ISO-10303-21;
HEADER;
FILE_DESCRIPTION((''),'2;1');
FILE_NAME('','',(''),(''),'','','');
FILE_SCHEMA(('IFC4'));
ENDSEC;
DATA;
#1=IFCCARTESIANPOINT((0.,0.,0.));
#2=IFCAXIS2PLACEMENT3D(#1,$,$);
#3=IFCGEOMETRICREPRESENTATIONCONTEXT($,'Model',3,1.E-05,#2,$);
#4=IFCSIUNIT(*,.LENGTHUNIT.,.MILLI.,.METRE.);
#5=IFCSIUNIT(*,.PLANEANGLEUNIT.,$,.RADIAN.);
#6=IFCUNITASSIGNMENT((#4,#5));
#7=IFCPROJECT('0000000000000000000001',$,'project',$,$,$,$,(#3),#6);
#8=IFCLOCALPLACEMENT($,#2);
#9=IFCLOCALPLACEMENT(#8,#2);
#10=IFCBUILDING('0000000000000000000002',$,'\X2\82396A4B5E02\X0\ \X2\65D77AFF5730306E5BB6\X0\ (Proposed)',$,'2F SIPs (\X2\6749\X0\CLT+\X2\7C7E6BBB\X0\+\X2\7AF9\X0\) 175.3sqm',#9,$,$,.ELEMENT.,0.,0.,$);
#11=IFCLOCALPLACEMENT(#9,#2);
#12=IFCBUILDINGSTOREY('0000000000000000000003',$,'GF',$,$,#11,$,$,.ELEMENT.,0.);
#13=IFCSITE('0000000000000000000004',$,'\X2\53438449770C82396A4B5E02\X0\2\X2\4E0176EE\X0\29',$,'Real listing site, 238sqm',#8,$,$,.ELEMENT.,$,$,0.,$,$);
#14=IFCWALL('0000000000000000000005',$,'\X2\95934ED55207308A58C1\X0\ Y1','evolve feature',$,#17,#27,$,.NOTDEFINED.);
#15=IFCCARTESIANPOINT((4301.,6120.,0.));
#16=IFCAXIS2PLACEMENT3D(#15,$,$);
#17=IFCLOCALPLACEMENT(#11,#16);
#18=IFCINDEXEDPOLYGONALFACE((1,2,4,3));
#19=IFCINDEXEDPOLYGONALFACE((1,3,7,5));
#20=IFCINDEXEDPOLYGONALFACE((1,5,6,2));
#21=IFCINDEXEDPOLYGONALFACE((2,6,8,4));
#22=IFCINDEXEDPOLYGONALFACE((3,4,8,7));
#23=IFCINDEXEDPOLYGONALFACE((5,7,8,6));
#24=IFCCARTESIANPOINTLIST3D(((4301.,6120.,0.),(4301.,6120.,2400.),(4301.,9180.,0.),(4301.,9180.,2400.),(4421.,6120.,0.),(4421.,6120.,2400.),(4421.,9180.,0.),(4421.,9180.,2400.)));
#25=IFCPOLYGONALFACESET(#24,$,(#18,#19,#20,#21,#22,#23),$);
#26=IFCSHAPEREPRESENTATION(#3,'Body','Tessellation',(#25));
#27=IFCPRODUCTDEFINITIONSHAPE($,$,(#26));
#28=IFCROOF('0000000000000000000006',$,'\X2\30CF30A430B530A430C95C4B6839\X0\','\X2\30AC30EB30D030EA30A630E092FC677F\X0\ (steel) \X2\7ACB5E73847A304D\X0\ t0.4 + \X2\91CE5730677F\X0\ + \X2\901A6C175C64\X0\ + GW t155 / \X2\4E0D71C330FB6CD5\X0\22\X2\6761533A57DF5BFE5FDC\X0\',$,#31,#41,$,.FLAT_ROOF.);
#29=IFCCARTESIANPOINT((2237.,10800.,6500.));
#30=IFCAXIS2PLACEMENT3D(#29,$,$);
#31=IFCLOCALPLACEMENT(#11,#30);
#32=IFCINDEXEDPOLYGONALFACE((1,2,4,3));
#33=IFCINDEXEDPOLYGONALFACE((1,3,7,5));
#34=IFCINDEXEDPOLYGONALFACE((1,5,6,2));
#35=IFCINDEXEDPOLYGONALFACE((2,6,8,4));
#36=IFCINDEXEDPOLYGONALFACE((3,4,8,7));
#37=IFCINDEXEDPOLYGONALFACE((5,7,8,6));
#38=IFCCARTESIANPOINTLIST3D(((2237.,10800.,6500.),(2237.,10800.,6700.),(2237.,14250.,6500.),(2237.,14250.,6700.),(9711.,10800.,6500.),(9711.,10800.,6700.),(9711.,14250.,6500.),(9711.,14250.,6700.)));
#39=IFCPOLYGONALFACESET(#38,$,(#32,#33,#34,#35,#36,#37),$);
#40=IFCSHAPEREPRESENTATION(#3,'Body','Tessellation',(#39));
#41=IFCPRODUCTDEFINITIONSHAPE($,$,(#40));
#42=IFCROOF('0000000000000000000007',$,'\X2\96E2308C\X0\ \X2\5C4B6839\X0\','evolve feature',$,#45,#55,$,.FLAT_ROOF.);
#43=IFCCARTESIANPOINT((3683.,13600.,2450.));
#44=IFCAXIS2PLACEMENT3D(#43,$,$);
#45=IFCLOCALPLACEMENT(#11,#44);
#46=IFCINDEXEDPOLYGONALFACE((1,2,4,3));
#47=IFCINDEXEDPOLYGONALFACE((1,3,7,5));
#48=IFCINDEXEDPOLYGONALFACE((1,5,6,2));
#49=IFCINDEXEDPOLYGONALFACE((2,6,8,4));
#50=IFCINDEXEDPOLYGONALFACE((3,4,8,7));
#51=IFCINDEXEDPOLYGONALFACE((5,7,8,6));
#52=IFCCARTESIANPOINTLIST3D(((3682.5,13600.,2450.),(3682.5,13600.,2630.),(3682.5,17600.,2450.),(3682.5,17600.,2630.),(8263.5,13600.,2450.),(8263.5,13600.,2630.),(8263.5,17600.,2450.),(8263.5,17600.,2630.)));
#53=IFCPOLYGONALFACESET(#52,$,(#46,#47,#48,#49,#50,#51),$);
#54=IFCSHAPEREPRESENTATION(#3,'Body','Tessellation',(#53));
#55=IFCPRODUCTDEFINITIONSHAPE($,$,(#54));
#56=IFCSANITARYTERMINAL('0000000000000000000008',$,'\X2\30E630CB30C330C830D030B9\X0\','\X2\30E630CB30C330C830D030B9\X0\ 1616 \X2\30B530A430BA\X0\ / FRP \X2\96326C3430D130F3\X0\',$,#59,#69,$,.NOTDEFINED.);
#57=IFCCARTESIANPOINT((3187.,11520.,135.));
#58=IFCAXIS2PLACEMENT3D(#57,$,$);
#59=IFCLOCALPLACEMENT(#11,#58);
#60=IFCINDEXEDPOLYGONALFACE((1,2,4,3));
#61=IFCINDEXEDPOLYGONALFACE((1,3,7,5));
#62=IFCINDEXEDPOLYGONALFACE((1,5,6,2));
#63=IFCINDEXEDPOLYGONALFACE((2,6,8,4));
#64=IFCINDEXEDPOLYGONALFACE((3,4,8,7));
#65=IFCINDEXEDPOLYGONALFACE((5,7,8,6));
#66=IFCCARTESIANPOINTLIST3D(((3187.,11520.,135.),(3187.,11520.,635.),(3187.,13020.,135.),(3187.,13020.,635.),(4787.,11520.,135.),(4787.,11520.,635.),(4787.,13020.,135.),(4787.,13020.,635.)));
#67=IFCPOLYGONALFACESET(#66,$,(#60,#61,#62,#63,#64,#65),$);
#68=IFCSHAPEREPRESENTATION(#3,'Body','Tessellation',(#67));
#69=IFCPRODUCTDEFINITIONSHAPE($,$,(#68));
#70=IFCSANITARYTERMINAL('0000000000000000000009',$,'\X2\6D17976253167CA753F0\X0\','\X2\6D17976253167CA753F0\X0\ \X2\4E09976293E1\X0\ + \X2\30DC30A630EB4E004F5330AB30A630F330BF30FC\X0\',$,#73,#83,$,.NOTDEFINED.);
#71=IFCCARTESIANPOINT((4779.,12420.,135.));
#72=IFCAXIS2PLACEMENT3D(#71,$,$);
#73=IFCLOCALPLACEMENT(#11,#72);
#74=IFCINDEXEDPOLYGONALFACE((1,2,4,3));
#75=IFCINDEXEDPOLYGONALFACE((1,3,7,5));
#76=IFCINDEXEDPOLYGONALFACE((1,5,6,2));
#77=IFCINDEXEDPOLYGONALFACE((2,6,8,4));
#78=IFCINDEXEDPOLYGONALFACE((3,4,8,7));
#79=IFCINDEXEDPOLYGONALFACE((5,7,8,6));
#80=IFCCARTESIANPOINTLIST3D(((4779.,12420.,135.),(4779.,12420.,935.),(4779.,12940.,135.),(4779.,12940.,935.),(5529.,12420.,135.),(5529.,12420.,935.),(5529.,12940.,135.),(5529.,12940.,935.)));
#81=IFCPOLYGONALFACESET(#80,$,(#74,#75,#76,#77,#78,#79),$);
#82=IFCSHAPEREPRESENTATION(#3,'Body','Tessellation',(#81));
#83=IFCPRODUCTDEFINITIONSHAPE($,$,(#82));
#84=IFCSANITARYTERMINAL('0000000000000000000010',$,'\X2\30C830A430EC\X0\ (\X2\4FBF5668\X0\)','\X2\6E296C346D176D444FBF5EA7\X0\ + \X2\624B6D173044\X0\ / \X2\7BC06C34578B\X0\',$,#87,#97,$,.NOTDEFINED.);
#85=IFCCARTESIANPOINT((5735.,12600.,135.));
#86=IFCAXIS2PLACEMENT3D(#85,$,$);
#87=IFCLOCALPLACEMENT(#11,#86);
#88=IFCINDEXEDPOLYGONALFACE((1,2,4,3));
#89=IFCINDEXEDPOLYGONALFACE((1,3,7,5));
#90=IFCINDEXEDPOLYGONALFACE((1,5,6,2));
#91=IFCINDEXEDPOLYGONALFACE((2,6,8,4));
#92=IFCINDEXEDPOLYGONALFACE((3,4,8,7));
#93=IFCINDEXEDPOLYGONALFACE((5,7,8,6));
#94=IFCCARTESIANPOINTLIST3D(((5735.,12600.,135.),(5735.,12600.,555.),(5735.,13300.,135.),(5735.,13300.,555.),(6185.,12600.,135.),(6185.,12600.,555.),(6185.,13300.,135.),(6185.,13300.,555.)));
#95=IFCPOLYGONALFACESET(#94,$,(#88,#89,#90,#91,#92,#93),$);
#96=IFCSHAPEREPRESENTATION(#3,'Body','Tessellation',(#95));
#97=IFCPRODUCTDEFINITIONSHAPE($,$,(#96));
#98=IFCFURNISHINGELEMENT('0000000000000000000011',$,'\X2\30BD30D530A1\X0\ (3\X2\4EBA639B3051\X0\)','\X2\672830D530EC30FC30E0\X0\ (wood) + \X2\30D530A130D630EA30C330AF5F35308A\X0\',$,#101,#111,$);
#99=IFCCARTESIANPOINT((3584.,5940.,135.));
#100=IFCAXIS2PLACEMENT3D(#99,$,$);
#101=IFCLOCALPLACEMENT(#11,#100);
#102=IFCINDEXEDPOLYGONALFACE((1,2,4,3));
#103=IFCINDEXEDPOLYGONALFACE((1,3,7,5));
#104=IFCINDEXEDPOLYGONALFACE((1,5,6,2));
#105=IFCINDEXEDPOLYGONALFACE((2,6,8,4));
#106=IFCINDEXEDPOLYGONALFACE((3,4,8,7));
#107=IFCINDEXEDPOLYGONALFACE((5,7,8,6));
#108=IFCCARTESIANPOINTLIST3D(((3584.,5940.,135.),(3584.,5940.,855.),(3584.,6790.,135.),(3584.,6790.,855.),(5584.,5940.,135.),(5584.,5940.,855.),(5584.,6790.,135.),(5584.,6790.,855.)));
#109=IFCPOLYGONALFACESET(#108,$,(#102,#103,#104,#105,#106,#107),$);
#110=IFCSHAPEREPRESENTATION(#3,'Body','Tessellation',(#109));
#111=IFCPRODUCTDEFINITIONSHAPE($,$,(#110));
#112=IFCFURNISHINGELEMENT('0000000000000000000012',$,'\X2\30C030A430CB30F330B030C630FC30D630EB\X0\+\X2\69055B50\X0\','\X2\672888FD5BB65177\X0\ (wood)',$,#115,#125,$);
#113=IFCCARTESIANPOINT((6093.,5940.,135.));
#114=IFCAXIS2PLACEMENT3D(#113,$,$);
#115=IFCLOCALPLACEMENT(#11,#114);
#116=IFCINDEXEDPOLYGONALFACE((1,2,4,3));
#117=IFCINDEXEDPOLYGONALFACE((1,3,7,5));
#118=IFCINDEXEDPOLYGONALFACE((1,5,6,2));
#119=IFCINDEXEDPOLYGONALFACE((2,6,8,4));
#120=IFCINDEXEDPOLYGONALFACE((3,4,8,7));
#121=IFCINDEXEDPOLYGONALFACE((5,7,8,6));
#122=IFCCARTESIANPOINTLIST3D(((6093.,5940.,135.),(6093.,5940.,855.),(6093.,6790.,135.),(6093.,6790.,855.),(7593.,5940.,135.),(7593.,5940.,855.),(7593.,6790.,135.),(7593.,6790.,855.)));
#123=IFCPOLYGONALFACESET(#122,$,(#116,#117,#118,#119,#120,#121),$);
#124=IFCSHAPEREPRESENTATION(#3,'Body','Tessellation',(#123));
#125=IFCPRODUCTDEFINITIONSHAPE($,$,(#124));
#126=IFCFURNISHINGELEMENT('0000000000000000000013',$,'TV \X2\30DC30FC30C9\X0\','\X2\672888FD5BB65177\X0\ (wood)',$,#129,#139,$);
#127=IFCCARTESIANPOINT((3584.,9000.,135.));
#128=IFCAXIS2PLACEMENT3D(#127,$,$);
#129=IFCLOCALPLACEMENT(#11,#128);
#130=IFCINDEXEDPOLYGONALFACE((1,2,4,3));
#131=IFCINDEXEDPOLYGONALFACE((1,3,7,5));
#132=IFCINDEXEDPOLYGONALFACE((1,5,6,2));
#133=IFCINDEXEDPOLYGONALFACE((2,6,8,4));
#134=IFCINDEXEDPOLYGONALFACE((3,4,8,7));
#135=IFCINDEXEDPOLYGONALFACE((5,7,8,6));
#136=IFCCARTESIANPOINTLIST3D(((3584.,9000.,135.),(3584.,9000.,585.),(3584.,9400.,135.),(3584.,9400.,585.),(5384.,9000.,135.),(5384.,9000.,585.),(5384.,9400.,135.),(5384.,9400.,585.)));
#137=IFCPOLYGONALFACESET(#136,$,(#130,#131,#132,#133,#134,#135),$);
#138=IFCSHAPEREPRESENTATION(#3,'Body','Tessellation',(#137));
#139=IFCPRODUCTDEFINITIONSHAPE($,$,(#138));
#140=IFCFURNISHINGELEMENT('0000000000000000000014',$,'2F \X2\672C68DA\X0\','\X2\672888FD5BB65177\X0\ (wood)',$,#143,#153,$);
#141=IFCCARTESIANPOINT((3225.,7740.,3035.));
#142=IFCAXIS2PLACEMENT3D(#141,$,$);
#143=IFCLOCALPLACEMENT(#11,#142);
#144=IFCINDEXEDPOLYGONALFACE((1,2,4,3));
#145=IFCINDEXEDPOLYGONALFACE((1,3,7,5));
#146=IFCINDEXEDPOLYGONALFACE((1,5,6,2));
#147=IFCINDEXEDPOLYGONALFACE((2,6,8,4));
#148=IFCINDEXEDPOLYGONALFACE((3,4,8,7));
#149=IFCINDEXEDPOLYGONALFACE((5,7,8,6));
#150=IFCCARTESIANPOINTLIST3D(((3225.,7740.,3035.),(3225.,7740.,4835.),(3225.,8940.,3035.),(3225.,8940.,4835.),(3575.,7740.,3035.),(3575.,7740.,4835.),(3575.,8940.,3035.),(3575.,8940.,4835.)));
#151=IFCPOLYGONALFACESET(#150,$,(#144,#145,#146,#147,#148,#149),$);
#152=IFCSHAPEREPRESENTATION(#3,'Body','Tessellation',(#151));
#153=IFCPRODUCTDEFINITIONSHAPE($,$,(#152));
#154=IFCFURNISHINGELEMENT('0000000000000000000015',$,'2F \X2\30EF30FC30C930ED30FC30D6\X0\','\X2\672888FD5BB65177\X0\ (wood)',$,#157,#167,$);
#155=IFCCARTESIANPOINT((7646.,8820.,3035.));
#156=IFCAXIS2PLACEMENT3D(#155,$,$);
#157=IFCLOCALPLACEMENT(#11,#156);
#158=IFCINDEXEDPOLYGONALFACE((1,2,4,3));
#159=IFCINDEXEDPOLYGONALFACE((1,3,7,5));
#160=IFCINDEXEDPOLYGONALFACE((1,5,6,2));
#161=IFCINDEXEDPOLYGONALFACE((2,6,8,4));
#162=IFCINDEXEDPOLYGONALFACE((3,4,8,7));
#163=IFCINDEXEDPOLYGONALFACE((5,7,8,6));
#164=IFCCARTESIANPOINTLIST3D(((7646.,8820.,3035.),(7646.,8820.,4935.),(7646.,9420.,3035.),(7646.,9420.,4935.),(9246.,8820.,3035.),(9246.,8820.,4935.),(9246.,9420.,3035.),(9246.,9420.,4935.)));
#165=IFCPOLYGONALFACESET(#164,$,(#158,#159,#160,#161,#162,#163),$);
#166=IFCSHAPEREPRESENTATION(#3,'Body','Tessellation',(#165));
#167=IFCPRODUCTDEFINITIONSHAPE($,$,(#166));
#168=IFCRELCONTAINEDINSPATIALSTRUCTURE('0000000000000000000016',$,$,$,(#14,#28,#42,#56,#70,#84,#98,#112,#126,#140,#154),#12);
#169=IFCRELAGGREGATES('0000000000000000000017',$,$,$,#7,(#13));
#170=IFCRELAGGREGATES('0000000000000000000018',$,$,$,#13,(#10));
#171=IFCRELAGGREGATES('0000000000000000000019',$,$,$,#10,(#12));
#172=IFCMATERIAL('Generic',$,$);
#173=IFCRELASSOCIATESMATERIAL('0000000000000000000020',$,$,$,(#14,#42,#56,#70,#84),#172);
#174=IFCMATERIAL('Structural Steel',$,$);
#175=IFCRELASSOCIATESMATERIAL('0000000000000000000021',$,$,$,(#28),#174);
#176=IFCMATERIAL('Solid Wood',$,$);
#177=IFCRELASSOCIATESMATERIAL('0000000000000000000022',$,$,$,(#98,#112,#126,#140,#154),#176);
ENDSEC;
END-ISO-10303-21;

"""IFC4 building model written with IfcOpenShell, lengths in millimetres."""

from ifc_helpers import new_model, si_unit, frame, frame_2d, origin, place, context, project, spatial, rectangle, extrude, material, element, save


model = new_model("IFC4")

# Units and contexts
model_context = context("Model", 3, precision=1e-05, world=origin())
ifc_project = project(units=[si_unit("LENGTHUNIT", "METRE", prefix="MILLI"), si_unit("PLANEANGLEUNIT", "RADIAN")], contexts=[model_context])

# Site, building, storey
site_placement = place(None, origin())
site = spatial("IfcSite", under=ifc_project, at=site_placement, Name="千葉県船橋市2丁目29", ObjectType="Real listing site, 238sqm", CompositionType="ELEMENT", RefElevation=0.0)
building_placement = place(site_placement, origin())
building = spatial("IfcBuilding", under=site, at=building_placement, Name="船橋市 旗竿地の家 (Proposed)", ObjectType="2F SIPs (杉CLT+籾殻+竹) 175.3sqm", CompositionType="ELEMENT", ElevationOfRefHeight=0.0, ElevationOfTerrain=0.0)
storey_placement = place(building_placement, origin())
storey = spatial("IfcBuildingStorey", under=building, at=storey_placement, Name="GF", CompositionType="ELEMENT", Elevation=0.0)

# Shared definitions
ifc_material_1 = material(Name="Generic")

# Shared definitions
ifc_material_2 = material(Name="Solid Wood")

# Wall
wall_1_placement = place(storey_placement, frame((4301.0, 6120.0, 0.0)))
element("IfcWall", 1, at=wall_1_placement, inside=storey, material=ifc_material_1, Name="間仕切り壁 Y1", Description="evolve feature", PredefinedType="NOTDEFINED", context=model_context, shape_type="SweptSolid", body=[
    extrude(rectangle(XDim=120.0, YDim=3060.0, at=frame_2d((60.0, 1530.0))), frame((4301.0, 6120.0, 0.0)), (0.0, 0.0, 1.0), 2400.0),
])

# Roofs
ifc_material_3 = material(Name="Structural Steel")
roof_1_placement = place(storey_placement, frame((2237.0, 10800.0, 6500.0)))
element("IfcRoof", 2, at=roof_1_placement, inside=storey, material=ifc_material_3, Name="ハイサイド屋根", Description="ガルバリウム鋼板 (steel) 立平葺き t0.4 + 野地板 + 通気層 + GW t155 / 不燃・法22条区域対応", PredefinedType="FLAT_ROOF", context=model_context, shape_type="SweptSolid", body=[
    extrude(rectangle(XDim=7474.0, YDim=3450.0, at=frame_2d((3737.0, 1725.0))), frame((2237.0, 10800.0, 6500.0)), (0.0, 0.0, 1.0), 200.0),
])
roof_2_placement = place(storey_placement, frame((3683.0, 13600.0, 2450.0)))
element("IfcRoof", 3, at=roof_2_placement, inside=storey, material=ifc_material_1, Name="離れ 屋根", Description="evolve feature", PredefinedType="FLAT_ROOF", context=model_context, shape_type="SweptSolid", body=[
    extrude(rectangle(XDim=4581.0, YDim=4000.0, at=frame_2d((2290.0, 2000.0))), frame((3683.0, 13600.0, 2450.0)), (0.0, 0.0, 1.0), 180.0),
])

# Sanitary terminals
sanitary_terminal_1_placement = place(storey_placement, frame((3187.0, 11520.0, 135.0)))
element("IfcSanitaryTerminal", 4, at=sanitary_terminal_1_placement, inside=storey, material=ifc_material_1, Name="ユニットバス", Description="ユニットバス 1616 サイズ / FRP 防水パン", PredefinedType="NOTDEFINED", context=model_context, shape_type="SweptSolid", body=[
    extrude(rectangle(XDim=1600.0, YDim=1500.0, at=frame_2d((800.0, 750.0))), frame((3187.0, 11520.0, 135.0)), (0.0, 0.0, 1.0), 500.0),
])
sanitary_terminal_2_placement = place(storey_placement, frame((4779.0, 12420.0, 135.0)))
element("IfcSanitaryTerminal", 5, at=sanitary_terminal_2_placement, inside=storey, material=ifc_material_1, Name="洗面化粧台", Description="洗面化粧台 三面鏡 + ボウル一体カウンター", PredefinedType="NOTDEFINED", context=model_context, shape_type="SweptSolid", body=[
    extrude(rectangle(XDim=750.0, YDim=520.0, at=frame_2d((375.0, 260.0))), frame((4779.0, 12420.0, 135.0)), (0.0, 0.0, 1.0), 800.0),
])
sanitary_terminal_3_placement = place(storey_placement, frame((5735.0, 12600.0, 135.0)))
element("IfcSanitaryTerminal", 6, at=sanitary_terminal_3_placement, inside=storey, material=ifc_material_1, Name="トイレ (便器)", Description="温水洗浄便座 + 手洗い / 節水型", PredefinedType="NOTDEFINED", context=model_context, shape_type="SweptSolid", body=[
    extrude(rectangle(XDim=450.0, YDim=700.0, at=frame_2d((225.0, 350.0))), frame((5735.0, 12600.0, 135.0)), (0.0, 0.0, 1.0), 420.0),
])

# Furnishing elements
furnishing_1_placement = place(storey_placement, frame((3584.0, 5940.0, 135.0)))
element("IfcFurnishingElement", 7, at=furnishing_1_placement, inside=storey, material=ifc_material_2, Name="ソファ (3人掛け)", Description="木フレーム (wood) + ファブリック張り", context=model_context, shape_type="SweptSolid", body=[
    extrude(rectangle(XDim=2000.0, YDim=850.0, at=frame_2d((1000.0, 425.0))), frame((3584.0, 5940.0, 135.0)), (0.0, 0.0, 1.0), 720.0),
])
furnishing_2_placement = place(storey_placement, frame((6093.0, 5940.0, 135.0)))
element("IfcFurnishingElement", 8, at=furnishing_2_placement, inside=storey, material=ifc_material_2, Name="ダイニングテーブル+椅子", Description="木製家具 (wood)", context=model_context, shape_type="SweptSolid", body=[
    extrude(rectangle(XDim=1500.0, YDim=850.0, at=frame_2d((750.0, 425.0))), frame((6093.0, 5940.0, 135.0)), (0.0, 0.0, 1.0), 720.0),
])
furnishing_3_placement = place(storey_placement, frame((3584.0, 9000.0, 135.0)))
element("IfcFurnishingElement", 9, at=furnishing_3_placement, inside=storey, material=ifc_material_2, Name="TV ボード", Description="木製家具 (wood)", context=model_context, shape_type="SweptSolid", body=[
    extrude(rectangle(XDim=1800.0, YDim=400.0, at=frame_2d((900.0, 200.0))), frame((3584.0, 9000.0, 135.0)), (0.0, 0.0, 1.0), 450.0),
])
furnishing_4_placement = place(storey_placement, frame((3225.0, 7740.0, 3035.0)))
element("IfcFurnishingElement", 10, at=furnishing_4_placement, inside=storey, material=ifc_material_2, Name="2F 本棚", Description="木製家具 (wood)", context=model_context, shape_type="SweptSolid", body=[
    extrude(rectangle(XDim=350.0, YDim=1200.0, at=frame_2d((175.0, 600.0))), frame((3225.0, 7740.0, 3035.0)), (0.0, 0.0, 1.0), 1800.0),
])
furnishing_5_placement = place(storey_placement, frame((7646.0, 8820.0, 3035.0)))
element("IfcFurnishingElement", 11, at=furnishing_5_placement, inside=storey, material=ifc_material_2, Name="2F ワードローブ", Description="木製家具 (wood)", context=model_context, shape_type="SweptSolid", body=[
    extrude(rectangle(XDim=1600.0, YDim=600.0, at=frame_2d((800.0, 300.0))), frame((7646.0, 8820.0, 3035.0)), (0.0, 0.0, 1.0), 1900.0),
])

save(model, "model.ifc")
